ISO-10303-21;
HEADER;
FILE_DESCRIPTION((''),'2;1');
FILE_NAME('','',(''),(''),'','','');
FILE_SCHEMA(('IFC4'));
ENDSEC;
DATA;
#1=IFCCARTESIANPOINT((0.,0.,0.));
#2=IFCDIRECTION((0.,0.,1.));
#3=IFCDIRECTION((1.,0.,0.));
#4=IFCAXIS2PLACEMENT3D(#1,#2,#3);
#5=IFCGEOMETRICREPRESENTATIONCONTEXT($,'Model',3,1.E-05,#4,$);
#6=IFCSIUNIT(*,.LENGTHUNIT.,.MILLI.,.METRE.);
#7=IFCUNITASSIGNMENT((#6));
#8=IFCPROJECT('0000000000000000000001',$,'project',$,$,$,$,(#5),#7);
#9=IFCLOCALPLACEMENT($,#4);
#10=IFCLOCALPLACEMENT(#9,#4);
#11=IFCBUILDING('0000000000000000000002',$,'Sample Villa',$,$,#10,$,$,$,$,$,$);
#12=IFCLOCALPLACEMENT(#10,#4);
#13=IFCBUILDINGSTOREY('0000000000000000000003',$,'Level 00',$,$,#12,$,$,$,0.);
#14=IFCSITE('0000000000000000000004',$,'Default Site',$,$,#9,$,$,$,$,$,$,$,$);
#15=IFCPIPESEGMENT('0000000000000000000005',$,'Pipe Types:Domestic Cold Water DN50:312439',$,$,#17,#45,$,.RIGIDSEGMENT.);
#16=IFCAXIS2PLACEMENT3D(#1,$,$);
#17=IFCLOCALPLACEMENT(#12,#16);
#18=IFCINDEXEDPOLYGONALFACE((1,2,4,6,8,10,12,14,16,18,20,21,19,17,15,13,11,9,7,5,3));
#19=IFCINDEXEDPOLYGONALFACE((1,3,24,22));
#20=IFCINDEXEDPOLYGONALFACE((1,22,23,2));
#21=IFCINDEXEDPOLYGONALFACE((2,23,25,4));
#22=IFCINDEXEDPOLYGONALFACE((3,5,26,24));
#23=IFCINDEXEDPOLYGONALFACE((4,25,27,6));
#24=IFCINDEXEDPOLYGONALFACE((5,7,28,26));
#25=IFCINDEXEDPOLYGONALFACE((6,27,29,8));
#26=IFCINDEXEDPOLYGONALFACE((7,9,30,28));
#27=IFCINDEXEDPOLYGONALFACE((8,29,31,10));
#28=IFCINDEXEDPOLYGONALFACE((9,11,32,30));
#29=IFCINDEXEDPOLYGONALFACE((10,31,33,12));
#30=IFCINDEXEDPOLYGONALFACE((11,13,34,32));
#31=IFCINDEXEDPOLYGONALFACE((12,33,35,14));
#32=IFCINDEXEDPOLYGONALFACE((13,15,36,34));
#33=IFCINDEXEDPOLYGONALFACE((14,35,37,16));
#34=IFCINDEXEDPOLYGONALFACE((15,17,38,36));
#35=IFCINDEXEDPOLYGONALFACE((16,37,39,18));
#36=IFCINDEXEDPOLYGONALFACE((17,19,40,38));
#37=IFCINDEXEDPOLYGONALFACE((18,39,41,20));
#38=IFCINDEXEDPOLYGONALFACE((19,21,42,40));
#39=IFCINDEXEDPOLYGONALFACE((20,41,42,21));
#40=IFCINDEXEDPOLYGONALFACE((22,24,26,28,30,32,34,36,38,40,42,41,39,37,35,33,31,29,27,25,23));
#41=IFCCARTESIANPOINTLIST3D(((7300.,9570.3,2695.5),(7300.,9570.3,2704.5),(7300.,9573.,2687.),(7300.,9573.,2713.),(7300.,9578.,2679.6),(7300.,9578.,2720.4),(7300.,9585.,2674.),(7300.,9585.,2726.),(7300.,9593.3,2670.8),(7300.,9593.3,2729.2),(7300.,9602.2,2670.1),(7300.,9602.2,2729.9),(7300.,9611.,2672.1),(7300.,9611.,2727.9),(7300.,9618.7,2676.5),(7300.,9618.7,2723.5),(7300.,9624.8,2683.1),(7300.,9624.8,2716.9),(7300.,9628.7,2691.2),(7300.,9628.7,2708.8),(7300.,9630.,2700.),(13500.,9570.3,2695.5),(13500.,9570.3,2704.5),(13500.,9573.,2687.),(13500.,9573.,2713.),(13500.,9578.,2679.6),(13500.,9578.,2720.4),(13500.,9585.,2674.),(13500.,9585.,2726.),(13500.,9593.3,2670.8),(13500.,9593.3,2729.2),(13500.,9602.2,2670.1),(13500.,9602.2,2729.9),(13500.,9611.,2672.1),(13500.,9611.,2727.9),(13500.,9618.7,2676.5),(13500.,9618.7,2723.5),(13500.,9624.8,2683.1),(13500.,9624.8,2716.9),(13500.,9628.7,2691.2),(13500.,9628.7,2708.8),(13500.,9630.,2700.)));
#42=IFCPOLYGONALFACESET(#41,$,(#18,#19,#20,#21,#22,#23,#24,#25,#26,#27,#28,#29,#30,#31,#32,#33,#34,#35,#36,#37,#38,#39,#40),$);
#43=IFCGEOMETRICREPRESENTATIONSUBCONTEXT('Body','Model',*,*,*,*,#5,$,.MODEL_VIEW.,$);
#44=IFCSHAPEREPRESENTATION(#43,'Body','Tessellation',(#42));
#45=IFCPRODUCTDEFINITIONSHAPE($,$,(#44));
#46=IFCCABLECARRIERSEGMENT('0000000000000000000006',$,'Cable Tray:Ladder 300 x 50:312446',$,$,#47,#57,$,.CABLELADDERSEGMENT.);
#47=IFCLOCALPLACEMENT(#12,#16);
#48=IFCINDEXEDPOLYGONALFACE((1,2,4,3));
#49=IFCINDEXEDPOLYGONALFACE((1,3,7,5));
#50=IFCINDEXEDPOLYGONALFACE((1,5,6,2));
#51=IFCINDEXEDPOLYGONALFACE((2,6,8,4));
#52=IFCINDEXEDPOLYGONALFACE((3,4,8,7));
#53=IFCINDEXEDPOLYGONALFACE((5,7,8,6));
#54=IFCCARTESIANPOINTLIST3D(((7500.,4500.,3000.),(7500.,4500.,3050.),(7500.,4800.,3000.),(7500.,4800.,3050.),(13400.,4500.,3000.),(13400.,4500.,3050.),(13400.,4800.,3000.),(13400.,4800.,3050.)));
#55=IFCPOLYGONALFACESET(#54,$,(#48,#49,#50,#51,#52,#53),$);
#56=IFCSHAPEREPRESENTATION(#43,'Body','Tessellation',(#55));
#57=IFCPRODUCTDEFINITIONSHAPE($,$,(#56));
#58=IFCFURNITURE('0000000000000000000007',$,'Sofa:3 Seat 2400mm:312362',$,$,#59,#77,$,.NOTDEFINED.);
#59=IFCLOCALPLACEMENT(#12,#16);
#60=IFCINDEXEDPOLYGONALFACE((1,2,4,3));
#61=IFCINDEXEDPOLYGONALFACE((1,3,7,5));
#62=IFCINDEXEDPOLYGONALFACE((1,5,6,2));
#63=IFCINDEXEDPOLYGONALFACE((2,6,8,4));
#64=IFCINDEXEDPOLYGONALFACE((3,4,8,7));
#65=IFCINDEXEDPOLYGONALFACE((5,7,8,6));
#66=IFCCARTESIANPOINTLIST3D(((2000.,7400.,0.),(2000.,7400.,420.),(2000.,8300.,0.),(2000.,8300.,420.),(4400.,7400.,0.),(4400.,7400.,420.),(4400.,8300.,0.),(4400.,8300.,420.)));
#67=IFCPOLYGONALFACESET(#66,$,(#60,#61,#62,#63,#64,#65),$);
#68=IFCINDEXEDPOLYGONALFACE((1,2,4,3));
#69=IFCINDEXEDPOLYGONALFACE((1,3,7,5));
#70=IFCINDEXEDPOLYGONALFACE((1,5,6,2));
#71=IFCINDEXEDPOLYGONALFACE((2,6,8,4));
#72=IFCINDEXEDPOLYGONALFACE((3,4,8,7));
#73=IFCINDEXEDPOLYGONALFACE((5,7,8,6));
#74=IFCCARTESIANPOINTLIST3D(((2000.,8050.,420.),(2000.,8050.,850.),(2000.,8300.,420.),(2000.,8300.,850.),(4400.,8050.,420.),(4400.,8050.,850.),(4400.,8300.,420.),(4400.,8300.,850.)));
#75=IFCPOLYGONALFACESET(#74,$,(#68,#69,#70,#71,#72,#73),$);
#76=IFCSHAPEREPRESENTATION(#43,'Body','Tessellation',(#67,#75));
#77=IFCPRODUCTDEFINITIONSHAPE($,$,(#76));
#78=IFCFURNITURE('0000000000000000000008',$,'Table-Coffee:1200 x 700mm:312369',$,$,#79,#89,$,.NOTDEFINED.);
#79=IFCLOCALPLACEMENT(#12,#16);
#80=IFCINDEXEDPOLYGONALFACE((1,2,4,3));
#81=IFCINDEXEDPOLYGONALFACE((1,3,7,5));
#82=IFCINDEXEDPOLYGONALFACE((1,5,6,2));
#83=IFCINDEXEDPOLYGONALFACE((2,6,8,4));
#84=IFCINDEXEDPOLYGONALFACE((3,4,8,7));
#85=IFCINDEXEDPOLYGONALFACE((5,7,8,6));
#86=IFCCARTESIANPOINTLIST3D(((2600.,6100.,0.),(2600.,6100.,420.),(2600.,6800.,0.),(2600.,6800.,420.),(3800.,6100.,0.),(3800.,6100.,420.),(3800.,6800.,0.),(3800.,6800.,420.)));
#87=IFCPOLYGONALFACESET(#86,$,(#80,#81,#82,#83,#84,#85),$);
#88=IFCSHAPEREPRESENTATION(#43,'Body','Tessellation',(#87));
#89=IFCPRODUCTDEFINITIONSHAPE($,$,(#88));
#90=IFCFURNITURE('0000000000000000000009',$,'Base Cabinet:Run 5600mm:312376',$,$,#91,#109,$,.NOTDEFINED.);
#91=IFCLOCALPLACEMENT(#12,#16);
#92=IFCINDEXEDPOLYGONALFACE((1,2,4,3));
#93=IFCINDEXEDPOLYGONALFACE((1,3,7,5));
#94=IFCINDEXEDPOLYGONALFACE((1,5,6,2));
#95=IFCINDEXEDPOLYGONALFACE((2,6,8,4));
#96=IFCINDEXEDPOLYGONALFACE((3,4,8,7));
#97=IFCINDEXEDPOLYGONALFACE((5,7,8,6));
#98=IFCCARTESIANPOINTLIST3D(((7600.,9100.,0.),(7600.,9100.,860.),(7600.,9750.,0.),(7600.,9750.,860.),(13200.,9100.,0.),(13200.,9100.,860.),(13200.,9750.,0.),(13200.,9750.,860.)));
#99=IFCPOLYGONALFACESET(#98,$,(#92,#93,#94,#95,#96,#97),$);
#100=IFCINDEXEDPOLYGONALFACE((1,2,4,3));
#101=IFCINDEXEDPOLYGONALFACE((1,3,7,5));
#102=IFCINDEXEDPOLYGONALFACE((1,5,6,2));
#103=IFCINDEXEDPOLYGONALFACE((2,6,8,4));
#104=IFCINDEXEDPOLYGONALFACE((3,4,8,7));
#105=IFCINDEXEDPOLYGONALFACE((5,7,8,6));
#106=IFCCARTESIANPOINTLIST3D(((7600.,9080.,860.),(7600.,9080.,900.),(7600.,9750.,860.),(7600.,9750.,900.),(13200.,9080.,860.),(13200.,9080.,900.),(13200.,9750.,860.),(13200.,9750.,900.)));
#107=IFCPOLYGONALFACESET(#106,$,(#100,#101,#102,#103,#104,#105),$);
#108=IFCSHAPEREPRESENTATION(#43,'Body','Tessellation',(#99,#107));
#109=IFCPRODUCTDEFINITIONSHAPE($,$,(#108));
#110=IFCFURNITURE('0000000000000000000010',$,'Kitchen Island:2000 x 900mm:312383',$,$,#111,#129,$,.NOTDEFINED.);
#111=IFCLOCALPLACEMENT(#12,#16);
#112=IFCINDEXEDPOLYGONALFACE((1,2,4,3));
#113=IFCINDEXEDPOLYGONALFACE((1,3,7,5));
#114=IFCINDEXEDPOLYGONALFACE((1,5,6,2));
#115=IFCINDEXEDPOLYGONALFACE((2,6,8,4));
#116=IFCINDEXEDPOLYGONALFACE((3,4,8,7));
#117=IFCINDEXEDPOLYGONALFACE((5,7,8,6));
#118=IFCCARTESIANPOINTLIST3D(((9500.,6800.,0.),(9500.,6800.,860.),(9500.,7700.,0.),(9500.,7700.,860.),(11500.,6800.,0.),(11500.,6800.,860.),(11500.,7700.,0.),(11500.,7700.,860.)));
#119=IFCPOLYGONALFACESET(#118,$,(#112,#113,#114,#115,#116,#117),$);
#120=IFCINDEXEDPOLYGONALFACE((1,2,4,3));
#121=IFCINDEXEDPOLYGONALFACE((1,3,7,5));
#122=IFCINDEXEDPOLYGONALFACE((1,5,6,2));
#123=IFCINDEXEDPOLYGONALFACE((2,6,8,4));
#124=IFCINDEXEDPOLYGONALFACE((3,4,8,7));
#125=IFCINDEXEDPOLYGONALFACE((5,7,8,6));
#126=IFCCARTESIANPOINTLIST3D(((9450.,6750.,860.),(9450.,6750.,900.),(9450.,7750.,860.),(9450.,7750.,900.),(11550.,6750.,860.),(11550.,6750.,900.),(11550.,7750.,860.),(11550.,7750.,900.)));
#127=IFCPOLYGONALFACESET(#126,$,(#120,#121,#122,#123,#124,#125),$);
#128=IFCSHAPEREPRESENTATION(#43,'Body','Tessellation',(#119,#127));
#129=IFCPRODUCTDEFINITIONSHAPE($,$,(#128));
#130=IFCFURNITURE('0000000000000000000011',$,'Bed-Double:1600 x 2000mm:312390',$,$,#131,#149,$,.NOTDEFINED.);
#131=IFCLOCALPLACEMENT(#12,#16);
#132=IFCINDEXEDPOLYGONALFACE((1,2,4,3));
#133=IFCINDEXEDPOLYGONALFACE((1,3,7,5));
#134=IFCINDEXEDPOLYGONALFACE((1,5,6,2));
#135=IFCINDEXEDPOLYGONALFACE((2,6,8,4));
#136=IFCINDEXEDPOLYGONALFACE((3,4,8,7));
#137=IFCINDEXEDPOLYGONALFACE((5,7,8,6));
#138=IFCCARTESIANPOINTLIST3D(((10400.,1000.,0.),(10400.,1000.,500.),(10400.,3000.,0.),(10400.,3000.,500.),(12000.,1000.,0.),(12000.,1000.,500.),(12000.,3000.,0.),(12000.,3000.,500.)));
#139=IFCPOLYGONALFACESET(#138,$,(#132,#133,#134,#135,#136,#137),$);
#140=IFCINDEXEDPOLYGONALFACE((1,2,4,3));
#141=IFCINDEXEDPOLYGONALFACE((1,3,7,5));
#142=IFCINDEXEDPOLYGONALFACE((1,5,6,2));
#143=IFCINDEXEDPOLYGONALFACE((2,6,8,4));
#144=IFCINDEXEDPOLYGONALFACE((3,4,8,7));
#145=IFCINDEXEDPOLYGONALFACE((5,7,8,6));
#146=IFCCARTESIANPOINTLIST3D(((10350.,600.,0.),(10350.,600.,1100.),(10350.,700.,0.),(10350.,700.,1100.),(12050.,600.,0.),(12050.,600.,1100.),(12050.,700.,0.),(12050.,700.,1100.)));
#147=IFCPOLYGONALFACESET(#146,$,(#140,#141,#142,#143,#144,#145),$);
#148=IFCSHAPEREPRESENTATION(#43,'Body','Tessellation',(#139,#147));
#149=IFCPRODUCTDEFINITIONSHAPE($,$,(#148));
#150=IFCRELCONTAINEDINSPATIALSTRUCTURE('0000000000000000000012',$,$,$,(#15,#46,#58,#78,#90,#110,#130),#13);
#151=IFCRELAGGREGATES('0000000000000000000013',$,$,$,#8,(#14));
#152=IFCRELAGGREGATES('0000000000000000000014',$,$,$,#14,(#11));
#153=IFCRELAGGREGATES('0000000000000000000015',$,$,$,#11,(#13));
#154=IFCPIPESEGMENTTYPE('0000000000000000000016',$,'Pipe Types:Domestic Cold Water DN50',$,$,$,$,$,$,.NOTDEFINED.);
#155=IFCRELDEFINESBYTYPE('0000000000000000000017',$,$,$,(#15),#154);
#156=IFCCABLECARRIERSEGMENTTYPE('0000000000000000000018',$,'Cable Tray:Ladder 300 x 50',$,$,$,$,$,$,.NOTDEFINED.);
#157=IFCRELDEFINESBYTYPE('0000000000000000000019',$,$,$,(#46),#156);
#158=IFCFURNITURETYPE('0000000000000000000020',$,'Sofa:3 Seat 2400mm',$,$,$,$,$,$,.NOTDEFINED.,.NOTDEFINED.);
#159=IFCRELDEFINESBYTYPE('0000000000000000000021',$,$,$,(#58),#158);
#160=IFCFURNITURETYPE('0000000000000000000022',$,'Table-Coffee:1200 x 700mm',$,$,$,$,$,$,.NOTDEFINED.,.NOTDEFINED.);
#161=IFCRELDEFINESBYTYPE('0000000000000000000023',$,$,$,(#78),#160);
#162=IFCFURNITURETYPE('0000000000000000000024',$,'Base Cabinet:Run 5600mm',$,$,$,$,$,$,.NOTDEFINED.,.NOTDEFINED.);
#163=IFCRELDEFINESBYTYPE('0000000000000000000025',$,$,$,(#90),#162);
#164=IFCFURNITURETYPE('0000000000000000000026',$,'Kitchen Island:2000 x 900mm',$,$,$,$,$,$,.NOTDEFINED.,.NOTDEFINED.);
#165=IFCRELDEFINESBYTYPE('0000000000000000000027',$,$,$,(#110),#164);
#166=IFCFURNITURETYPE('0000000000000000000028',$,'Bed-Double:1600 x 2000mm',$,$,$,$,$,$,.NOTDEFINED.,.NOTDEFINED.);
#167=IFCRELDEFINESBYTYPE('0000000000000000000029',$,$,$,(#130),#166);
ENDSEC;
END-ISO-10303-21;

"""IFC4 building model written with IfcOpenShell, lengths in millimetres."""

from ifc_helpers import new_model, si_unit, frame, frame_2d, origin_with_axes, place, context, subcontext, project, spatial, rectangle, circle, extrude, type_object, element, save


model = new_model("IFC4")

# Units and contexts
model_context = context("Model", 3, precision=1e-05, world=origin_with_axes())
body_context = subcontext(model_context, "Body", "Model", "MODEL_VIEW")
ifc_project = project(units=[si_unit("LENGTHUNIT", "METRE", prefix="MILLI")], contexts=[model_context])

# Site, building, storey
site_placement = place(None, origin_with_axes())
site = spatial("IfcSite", under=ifc_project, at=site_placement, Name="Default Site")
building_placement = place(site_placement, origin_with_axes())
building = spatial("IfcBuilding", under=site, at=building_placement, Name="Sample Villa")
storey_placement = place(building_placement, origin_with_axes())
storey = spatial("IfcBuildingStorey", under=building, at=storey_placement, Name="Level 00", Elevation=0.0)

# Pipe segment
pipe_segment_type = type_object("IfcPipeSegmentType", Name="Pipe Types:Domestic Cold Water DN50", PredefinedType="NOTDEFINED")
pipe_segment_placement = place(storey_placement, origin_with_axes())
element("IfcPipeSegment", 1, at=pipe_segment_placement, inside=storey, type_object=pipe_segment_type, Name="Pipe Types:Domestic Cold Water DN50:312439", PredefinedType="RIGIDSEGMENT", context=body_context, shape_type="SweptSolid", body=[
    extrude(circle(Radius=30.0), frame((7300.0, 9600.0, 2700.0), z_axis=(1.0, 0.0, 0.0), x_axis=(0.0, 1.0, 0.0)), (0.0, 0.0, 1.0), 6200.0),
])

# Cable carrier segment
cable_carrier_segment_type = type_object("IfcCableCarrierSegmentType", Name="Cable Tray:Ladder 300 x 50", PredefinedType="NOTDEFINED")
cable_carrier_segment_placement = place(storey_placement, origin_with_axes())
element("IfcCableCarrierSegment", 2, at=cable_carrier_segment_placement, inside=storey, type_object=cable_carrier_segment_type, Name="Cable Tray:Ladder 300 x 50:312446", PredefinedType="CABLELADDERSEGMENT", context=body_context, shape_type="SweptSolid", body=[
    extrude(rectangle(XDim=5900.0, YDim=300.0, at=frame_2d((2950.0, 150.0))), frame((7500.0, 4500.0, 3000.0)), (0.0, 0.0, 1.0), 50.0),
])

# Furniture
furniture_type_1 = type_object("IfcFurnitureType", Name="Sofa:3 Seat 2400mm", AssemblyPlace="NOTDEFINED", PredefinedType="NOTDEFINED")
furniture_1_placement = place(storey_placement, origin_with_axes())
element("IfcFurniture", 3, at=furniture_1_placement, inside=storey, type_object=furniture_type_1, Name="Sofa:3 Seat 2400mm:312362", PredefinedType="NOTDEFINED", context=body_context, shape_type="SweptSolid", body=[
    extrude(rectangle(XDim=2400.0, YDim=900.0, at=frame_2d((1200.0, 450.0))), frame((2000.0, 7400.0, 0.0)), (0.0, 0.0, 1.0), 420.0),
    extrude(rectangle(XDim=2400.0, YDim=250.0, at=frame_2d((1200.0, 125.0))), frame((2000.0, 8050.0, 420.0)), (0.0, 0.0, 1.0), 430.0),
])
furniture_type_2 = type_object("IfcFurnitureType", Name="Table-Coffee:1200 x 700mm", AssemblyPlace="NOTDEFINED", PredefinedType="NOTDEFINED")
furniture_2_placement = place(storey_placement, origin_with_axes())
element("IfcFurniture", 4, at=furniture_2_placement, inside=storey, type_object=furniture_type_2, Name="Table-Coffee:1200 x 700mm:312369", PredefinedType="NOTDEFINED", context=body_context, shape_type="SweptSolid", body=[
    extrude(rectangle(XDim=1200.0, YDim=700.0, at=frame_2d((600.0, 350.0))), frame((2600.0, 6100.0, 0.0)), (0.0, 0.0, 1.0), 420.0),
])
furniture_type_3 = type_object("IfcFurnitureType", Name="Base Cabinet:Run 5600mm", AssemblyPlace="NOTDEFINED", PredefinedType="NOTDEFINED")
furniture_3_placement = place(storey_placement, origin_with_axes())
element("IfcFurniture", 5, at=furniture_3_placement, inside=storey, type_object=furniture_type_3, Name="Base Cabinet:Run 5600mm:312376", PredefinedType="NOTDEFINED", context=body_context, shape_type="SweptSolid", body=[
    extrude(rectangle(XDim=5600.0, YDim=650.0, at=frame_2d((2800.0, 325.0))), frame((7600.0, 9100.0, 0.0)), (0.0, 0.0, 1.0), 860.0),
    extrude(rectangle(XDim=5600.0, YDim=670.0, at=frame_2d((2800.0, 335.0))), frame((7600.0, 9080.0, 860.0)), (0.0, 0.0, 1.0), 40.0),
])
furniture_type_4 = type_object("IfcFurnitureType", Name="Kitchen Island:2000 x 900mm", AssemblyPlace="NOTDEFINED", PredefinedType="NOTDEFINED")
furniture_4_placement = place(storey_placement, origin_with_axes())
element("IfcFurniture", 6, at=furniture_4_placement, inside=storey, type_object=furniture_type_4, Name="Kitchen Island:2000 x 900mm:312383", PredefinedType="NOTDEFINED", context=body_context, shape_type="SweptSolid", body=[
    extrude(rectangle(XDim=2000.0, YDim=900.0, at=frame_2d((1000.0, 450.0))), frame((9500.0, 6800.0, 0.0)), (0.0, 0.0, 1.0), 860.0),
    extrude(rectangle(XDim=2100.0, YDim=1000.0, at=frame_2d((1050.0, 500.0))), frame((9450.0, 6750.0, 860.0)), (0.0, 0.0, 1.0), 40.0),
])
furniture_type_5 = type_object("IfcFurnitureType", Name="Bed-Double:1600 x 2000mm", AssemblyPlace="NOTDEFINED", PredefinedType="NOTDEFINED")
furniture_5_placement = place(storey_placement, origin_with_axes())
element("IfcFurniture", 7, at=furniture_5_placement, inside=storey, type_object=furniture_type_5, Name="Bed-Double:1600 x 2000mm:312390", PredefinedType="NOTDEFINED", context=body_context, shape_type="SweptSolid", body=[
    extrude(rectangle(XDim=1600.0, YDim=2000.0, at=frame_2d((800.0, 1000.0))), frame((10400.0, 1000.0, 0.0)), (0.0, 0.0, 1.0), 500.0),
    extrude(rectangle(XDim=1700.0, YDim=100.0, at=frame_2d((850.0, 50.0))), frame((10350.0, 600.0, 0.0)), (0.0, 0.0, 1.0), 1100.0),
])

save(model, "model.ifc")
